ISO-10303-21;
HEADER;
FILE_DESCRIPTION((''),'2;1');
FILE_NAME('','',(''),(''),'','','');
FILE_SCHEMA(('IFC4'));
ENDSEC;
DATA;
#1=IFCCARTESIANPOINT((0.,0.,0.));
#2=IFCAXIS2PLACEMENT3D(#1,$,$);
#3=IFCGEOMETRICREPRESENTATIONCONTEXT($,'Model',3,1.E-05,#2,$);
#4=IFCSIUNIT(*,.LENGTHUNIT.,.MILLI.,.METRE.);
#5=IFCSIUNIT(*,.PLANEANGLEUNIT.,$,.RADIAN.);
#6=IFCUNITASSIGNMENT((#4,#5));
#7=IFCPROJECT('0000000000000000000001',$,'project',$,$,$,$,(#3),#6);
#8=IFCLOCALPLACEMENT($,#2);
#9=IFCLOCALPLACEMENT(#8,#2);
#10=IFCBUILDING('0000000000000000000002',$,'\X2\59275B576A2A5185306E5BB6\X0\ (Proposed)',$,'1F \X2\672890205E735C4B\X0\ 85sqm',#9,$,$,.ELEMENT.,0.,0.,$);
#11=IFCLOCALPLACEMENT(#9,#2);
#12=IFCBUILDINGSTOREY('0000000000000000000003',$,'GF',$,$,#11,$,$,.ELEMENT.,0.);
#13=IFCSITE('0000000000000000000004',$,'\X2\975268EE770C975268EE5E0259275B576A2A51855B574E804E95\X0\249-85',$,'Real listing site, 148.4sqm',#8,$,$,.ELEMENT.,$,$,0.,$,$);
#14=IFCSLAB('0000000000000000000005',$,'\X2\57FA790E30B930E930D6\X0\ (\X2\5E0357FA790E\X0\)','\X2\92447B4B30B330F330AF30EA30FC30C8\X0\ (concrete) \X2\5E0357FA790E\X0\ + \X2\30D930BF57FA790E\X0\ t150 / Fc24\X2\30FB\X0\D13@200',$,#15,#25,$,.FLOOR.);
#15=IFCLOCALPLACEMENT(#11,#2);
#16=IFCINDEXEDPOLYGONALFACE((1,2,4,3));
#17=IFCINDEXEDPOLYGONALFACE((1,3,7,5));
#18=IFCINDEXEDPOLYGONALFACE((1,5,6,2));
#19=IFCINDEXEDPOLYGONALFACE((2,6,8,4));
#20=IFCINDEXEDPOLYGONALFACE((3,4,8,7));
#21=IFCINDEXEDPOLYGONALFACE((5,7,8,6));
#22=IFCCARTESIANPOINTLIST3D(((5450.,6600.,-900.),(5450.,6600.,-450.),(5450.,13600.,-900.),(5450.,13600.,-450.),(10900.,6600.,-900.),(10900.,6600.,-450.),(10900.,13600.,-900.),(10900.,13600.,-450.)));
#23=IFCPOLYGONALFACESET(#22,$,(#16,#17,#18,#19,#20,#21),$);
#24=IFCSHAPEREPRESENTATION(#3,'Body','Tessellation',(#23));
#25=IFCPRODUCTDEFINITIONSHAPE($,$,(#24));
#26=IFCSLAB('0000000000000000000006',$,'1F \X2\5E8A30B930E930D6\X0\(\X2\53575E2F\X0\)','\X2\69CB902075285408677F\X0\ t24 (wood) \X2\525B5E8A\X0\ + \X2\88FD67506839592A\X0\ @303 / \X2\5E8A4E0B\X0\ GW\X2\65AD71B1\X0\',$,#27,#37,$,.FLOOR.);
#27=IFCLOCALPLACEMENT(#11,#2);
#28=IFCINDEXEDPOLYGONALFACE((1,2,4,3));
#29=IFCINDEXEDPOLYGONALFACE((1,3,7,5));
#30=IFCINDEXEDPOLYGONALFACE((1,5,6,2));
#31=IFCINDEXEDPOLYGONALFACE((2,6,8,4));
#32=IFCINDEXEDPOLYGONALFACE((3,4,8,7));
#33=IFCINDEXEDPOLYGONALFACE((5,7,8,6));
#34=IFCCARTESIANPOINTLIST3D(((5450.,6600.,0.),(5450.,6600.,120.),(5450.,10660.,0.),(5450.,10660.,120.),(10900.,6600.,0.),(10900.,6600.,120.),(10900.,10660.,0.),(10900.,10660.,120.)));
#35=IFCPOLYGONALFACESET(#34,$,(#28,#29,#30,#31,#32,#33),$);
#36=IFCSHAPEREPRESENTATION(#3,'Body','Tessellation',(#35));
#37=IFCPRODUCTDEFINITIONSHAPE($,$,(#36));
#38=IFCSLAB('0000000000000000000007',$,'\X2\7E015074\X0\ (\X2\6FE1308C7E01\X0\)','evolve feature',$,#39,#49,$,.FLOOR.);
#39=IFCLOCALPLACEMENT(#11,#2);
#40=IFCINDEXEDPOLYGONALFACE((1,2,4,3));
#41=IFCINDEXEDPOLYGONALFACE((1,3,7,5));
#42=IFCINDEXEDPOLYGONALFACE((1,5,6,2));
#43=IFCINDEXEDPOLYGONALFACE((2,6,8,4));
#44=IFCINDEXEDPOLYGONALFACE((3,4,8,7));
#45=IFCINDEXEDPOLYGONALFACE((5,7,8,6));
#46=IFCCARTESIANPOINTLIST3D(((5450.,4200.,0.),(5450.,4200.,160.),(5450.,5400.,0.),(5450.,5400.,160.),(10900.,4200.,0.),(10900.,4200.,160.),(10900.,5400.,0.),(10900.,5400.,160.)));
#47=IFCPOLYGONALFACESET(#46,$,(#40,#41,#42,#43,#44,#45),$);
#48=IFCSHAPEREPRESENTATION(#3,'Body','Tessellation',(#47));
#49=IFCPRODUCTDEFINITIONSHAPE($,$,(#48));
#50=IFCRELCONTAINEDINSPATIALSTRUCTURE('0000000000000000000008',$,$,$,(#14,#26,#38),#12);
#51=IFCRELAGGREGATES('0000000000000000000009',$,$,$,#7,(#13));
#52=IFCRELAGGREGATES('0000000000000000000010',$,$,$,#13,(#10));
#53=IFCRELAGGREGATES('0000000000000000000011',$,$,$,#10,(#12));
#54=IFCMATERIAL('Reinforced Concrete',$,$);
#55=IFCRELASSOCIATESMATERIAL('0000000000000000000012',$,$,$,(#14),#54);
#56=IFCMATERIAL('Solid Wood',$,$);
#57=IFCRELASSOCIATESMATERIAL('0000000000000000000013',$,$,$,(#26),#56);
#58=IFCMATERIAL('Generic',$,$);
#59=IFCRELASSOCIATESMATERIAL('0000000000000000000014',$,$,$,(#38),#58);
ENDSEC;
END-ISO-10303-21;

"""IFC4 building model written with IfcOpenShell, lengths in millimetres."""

from ifc_helpers import new_model, si_unit, frame, frame_2d, origin, place, context, project, spatial, rectangle, extrude, material, element, save


model = new_model("IFC4")

# Units and contexts
model_context = context("Model", 3, precision=1e-05, world=origin())
ifc_project = project(units=[si_unit("LENGTHUNIT", "METRE", prefix="MILLI"), si_unit("PLANEANGLEUNIT", "RADIAN")], contexts=[model_context])

# Site, building, storey
site_placement = place(None, origin())
site = spatial("IfcSite", under=ifc_project, at=site_placement, Name="青森県青森市大字横内字亀井249-85", ObjectType="Real listing site, 148.4sqm", CompositionType="ELEMENT", RefElevation=0.0)
building_placement = place(site_placement, origin())
building = spatial("IfcBuilding", under=site, at=building_placement, Name="大字横内の家 (Proposed)", ObjectType="1F 木造平屋 85sqm", CompositionType="ELEMENT", ElevationOfRefHeight=0.0, ElevationOfTerrain=0.0)
storey_placement = place(building_placement, origin())
storey = spatial("IfcBuildingStorey", under=building, at=storey_placement, Name="GF", CompositionType="ELEMENT", Elevation=0.0)

# Slabs
ifc_material_1 = material(Name="Reinforced Concrete")
slab_1_placement = place(storey_placement, frame((2725.0, 3300.0, -450.0)))
element("IfcSlab", 1, at=slab_1_placement, inside=storey, material=ifc_material_1, Name="基礎スラブ (布基礎)", Description="鉄筋コンクリート (concrete) 布基礎 + ベタ基礎 t150 / Fc24・D13@200", PredefinedType="FLOOR", context=model_context, shape_type="SweptSolid", body=[
    extrude(rectangle(XDim=5450.0, YDim=7000.0, at=frame_2d((2725.0, 3500.0))), frame((2725.0, 3300.0, -450.0)), (0.0, 0.0, 1.0), 450.0),
])
ifc_material_2 = material(Name="Solid Wood")
slab_2_placement = place(storey_placement, frame((2725.0, 3300.0, 0.0)))
element("IfcSlab", 2, at=slab_2_placement, inside=storey, material=ifc_material_2, Name="1F 床スラブ(南帯)", Description="構造用合板 t24 (wood) 剛床 + 製材根太 @303 / 床下 GW断熱", PredefinedType="FLOOR", context=model_context, shape_type="SweptSolid", body=[
    extrude(rectangle(XDim=5450.0, YDim=4060.0, at=frame_2d((2725.0, 2030.0))), frame((2725.0, 3300.0, 0.0)), (0.0, 0.0, 1.0), 120.0),
])
ifc_material_3 = material(Name="Generic")
slab_3_placement = place(storey_placement, frame((2725.0, 2100.0, 0.0)))
element("IfcSlab", 3, at=slab_3_placement, inside=storey, material=ifc_material_3, Name="縁側 (濡れ縁)", Description="evolve feature", PredefinedType="FLOOR", context=model_context, shape_type="SweptSolid", body=[
    extrude(rectangle(XDim=5450.0, YDim=1200.0, at=frame_2d((2725.0, 600.0))), frame((2725.0, 2100.0, 0.0)), (0.0, 0.0, 1.0), 160.0),
])

save(model, "model.ifc")
